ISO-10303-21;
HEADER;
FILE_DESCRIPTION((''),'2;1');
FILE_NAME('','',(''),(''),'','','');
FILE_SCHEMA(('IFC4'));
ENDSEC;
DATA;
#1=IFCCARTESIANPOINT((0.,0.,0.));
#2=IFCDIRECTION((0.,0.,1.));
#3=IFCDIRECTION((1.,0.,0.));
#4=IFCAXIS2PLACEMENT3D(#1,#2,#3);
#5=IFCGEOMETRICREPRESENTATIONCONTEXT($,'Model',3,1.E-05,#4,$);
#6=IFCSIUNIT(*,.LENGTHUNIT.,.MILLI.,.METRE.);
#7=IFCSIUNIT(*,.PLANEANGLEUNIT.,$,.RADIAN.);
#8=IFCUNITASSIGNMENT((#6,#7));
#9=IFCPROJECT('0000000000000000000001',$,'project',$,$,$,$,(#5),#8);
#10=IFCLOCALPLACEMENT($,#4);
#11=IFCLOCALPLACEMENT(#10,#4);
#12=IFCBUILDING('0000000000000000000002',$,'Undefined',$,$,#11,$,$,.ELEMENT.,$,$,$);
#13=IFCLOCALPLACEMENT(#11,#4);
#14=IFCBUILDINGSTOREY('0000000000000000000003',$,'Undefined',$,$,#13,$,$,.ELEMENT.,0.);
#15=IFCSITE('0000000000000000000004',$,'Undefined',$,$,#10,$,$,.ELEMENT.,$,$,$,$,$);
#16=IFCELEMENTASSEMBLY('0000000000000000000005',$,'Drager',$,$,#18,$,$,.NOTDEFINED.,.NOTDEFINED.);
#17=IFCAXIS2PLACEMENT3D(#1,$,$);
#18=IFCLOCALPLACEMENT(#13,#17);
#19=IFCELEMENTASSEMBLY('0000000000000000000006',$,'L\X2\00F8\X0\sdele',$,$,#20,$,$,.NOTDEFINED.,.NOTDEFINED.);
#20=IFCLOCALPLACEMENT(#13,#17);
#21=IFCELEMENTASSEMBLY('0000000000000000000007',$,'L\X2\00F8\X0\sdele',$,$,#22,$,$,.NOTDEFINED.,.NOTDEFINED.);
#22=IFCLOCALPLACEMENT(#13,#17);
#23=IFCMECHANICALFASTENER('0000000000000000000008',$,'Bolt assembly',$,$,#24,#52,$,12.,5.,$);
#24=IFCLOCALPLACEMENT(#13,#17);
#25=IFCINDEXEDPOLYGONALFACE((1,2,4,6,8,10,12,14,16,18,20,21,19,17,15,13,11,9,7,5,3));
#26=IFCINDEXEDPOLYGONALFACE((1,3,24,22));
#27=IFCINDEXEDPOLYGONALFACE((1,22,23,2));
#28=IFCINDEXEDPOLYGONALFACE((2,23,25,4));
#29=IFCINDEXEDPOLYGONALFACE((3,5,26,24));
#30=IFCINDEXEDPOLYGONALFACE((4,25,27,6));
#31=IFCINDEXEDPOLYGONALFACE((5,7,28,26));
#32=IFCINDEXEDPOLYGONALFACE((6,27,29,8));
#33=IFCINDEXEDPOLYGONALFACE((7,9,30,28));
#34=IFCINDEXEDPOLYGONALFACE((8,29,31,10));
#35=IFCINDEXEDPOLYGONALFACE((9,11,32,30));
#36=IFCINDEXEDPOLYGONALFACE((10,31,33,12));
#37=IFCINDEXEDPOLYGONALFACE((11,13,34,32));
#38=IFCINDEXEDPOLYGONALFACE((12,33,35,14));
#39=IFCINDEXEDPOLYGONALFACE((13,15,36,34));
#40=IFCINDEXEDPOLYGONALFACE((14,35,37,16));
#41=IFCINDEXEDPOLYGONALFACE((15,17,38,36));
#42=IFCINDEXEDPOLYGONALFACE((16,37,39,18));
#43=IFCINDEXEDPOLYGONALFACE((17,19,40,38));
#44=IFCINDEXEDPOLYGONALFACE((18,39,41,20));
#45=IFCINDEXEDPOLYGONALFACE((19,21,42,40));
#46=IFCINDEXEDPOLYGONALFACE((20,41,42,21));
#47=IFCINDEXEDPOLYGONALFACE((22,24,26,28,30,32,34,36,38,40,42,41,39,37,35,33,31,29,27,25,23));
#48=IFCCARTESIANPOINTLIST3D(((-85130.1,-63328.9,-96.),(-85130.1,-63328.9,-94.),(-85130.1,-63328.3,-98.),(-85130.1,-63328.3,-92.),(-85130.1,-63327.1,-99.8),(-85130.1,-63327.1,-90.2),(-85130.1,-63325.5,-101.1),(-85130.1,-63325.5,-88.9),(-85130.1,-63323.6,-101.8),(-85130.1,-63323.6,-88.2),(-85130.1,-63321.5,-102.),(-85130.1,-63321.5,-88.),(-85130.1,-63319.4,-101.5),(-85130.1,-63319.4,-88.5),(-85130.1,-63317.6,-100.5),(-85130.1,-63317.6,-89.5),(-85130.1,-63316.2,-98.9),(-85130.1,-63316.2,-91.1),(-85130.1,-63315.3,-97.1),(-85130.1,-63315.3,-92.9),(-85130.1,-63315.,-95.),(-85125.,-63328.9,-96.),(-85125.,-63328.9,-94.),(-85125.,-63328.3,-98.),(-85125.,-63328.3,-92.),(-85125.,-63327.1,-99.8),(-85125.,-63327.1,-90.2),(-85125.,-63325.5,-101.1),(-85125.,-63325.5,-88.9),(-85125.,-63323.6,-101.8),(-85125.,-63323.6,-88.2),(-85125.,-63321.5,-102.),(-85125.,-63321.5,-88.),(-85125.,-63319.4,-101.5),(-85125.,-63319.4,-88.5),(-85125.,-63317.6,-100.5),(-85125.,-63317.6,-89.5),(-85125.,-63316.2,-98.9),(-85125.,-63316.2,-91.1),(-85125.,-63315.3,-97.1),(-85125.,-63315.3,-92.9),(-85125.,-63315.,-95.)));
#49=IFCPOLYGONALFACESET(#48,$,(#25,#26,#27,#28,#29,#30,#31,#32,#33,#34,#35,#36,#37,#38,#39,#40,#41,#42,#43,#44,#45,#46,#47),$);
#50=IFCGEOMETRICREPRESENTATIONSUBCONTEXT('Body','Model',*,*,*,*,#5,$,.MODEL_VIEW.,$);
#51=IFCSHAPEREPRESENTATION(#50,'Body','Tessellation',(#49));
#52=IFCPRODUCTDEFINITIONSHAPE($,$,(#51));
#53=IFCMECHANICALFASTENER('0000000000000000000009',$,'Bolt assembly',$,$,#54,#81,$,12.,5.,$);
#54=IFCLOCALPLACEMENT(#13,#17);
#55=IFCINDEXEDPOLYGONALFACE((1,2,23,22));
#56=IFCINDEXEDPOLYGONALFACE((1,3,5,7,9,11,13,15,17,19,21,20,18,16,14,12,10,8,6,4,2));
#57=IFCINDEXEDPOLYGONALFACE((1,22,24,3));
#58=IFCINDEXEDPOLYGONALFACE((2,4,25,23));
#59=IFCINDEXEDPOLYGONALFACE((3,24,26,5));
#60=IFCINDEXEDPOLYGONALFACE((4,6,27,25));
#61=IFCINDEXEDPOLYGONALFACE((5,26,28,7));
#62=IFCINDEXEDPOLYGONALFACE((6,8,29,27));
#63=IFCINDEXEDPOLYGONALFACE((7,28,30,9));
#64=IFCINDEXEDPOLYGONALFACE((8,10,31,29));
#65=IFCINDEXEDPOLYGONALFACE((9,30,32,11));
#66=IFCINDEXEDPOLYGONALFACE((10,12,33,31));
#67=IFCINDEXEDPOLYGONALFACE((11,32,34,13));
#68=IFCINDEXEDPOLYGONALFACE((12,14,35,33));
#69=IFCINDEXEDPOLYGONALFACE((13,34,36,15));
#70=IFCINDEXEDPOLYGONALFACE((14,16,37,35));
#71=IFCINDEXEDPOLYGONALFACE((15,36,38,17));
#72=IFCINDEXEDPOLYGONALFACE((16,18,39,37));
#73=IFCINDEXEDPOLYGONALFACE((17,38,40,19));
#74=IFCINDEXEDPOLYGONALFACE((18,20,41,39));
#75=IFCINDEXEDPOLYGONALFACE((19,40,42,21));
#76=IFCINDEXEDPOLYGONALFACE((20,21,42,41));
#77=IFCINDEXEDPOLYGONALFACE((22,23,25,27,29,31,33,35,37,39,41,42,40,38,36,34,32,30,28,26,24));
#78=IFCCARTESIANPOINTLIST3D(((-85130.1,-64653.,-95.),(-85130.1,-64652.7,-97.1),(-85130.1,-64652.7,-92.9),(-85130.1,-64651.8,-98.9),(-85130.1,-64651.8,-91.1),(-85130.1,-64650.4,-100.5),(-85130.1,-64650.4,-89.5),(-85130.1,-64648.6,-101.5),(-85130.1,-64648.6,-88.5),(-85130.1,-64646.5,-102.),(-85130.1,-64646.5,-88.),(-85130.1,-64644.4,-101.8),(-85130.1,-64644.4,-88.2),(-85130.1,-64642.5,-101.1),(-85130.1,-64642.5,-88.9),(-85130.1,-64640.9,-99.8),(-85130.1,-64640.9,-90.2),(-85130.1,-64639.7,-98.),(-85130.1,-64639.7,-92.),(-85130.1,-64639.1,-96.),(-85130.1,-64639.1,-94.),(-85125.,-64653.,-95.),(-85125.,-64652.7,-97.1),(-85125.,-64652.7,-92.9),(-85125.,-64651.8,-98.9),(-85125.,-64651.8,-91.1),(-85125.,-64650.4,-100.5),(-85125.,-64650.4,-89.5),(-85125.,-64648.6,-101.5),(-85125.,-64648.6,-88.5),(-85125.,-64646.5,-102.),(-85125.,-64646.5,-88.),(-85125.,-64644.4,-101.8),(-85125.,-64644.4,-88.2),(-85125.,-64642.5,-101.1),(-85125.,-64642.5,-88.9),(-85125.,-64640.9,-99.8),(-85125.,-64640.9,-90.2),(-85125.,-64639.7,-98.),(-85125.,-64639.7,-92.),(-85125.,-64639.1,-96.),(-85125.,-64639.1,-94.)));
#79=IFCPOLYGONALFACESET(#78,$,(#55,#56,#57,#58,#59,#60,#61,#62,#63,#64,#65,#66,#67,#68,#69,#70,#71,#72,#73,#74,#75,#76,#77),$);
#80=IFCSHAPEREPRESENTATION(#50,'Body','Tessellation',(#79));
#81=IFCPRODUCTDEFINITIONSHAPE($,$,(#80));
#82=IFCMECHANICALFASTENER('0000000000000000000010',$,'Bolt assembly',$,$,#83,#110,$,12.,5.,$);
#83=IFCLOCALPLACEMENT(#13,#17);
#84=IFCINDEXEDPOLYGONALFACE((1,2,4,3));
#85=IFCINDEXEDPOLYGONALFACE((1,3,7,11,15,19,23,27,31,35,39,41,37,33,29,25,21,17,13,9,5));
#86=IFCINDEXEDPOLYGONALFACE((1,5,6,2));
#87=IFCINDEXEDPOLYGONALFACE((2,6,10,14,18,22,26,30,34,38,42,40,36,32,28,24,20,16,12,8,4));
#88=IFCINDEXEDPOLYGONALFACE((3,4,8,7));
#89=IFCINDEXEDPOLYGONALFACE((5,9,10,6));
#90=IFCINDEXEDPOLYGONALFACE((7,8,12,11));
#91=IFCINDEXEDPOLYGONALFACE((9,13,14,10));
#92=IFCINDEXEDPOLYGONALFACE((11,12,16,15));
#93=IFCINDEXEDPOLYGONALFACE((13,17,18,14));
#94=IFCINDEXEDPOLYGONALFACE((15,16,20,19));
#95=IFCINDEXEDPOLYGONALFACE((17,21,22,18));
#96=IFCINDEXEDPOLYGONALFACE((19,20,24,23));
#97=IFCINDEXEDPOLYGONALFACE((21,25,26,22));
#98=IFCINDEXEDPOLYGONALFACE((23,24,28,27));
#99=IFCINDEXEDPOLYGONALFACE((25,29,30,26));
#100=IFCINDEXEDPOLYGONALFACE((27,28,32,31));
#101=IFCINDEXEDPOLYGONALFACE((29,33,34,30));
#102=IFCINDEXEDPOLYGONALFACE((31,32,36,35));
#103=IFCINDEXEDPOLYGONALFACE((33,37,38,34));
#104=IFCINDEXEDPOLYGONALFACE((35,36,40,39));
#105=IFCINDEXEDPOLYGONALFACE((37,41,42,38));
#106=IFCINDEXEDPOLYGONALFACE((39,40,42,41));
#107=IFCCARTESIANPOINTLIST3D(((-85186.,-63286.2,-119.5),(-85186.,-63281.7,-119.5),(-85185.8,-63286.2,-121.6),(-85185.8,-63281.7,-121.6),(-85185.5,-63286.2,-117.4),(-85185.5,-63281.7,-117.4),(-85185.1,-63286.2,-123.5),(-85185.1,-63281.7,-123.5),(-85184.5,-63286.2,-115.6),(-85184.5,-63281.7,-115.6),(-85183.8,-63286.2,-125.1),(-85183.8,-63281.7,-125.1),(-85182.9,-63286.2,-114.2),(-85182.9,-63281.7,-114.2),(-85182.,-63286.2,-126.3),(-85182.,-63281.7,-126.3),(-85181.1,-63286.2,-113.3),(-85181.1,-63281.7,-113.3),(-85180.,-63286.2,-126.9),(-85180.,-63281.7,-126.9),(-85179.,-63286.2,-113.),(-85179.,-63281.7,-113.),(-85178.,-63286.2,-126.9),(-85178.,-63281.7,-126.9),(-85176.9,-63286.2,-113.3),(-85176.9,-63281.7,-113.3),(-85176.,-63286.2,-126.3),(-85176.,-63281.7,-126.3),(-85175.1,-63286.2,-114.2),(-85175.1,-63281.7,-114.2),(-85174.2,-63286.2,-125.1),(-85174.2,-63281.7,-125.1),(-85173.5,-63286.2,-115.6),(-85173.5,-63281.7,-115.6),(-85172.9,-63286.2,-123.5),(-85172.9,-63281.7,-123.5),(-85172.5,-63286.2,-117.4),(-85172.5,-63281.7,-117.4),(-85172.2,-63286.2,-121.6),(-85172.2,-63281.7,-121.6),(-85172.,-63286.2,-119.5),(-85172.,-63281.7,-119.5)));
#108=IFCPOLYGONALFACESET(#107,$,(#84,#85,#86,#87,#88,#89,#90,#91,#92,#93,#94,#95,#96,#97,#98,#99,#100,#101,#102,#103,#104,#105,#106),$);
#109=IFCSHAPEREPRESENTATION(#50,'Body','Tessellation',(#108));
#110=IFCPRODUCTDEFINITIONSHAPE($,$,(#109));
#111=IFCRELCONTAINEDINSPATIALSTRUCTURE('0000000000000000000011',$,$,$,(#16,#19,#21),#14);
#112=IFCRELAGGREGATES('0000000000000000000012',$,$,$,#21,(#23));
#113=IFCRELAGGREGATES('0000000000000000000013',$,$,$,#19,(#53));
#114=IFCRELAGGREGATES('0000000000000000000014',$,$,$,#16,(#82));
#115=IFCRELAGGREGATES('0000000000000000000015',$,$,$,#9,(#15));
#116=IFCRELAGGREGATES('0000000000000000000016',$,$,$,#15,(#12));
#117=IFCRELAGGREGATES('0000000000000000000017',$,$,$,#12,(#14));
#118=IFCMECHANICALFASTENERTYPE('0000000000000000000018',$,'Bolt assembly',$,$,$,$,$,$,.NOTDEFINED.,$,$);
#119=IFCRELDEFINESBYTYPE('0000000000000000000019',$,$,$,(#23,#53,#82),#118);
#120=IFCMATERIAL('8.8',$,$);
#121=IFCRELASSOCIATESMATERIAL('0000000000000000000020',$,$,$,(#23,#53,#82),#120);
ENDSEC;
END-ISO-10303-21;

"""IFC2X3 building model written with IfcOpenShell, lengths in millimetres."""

from ifc_helpers import new_model, si_unit, frame, origin_with_axes, origin_2d_with_axis, place, context, subcontext, project, spatial, circle, extrude, source, transform, mapped, material, type_object, element, aggregate, save


model = new_model("IFC2X3")

# Units and contexts
model_context = context("Model", 3, precision=1e-05, world=origin_with_axes())
body_context = subcontext(model_context, "Body", "Model", "MODEL_VIEW")
ifc_project = project(units=[si_unit("LENGTHUNIT", "METRE", prefix="MILLI"), si_unit("PLANEANGLEUNIT", "RADIAN")], contexts=[model_context])

# Site, building, storey
site_placement = place(None, origin_with_axes())
site = spatial("IfcSite", under=ifc_project, at=site_placement, Name="Undefined", CompositionType="ELEMENT")
building_placement = place(site_placement, origin_with_axes())
building = spatial("IfcBuilding", under=site, at=building_placement, Name="Undefined", CompositionType="ELEMENT")
storey_placement = place(building_placement, origin_with_axes())
storey = spatial("IfcBuildingStorey", under=building, at=storey_placement, Name="Undefined", CompositionType="ELEMENT", Elevation=0.0)

# Element assembly
assembly_1_placement = place(storey_placement, origin_with_axes())
assembly_1 = element("IfcElementAssembly", 1, at=assembly_1_placement, inside=storey, Name="Drager", AssemblyPlace="NOTDEFINED", PredefinedType="NOTDEFINED")

# Element assemblies
assembly_2_placement = place(storey_placement, origin_with_axes())
assembly_2 = element("IfcElementAssembly", 2, at=assembly_2_placement, inside=storey, Name="Løsdele", AssemblyPlace="NOTDEFINED", PredefinedType="NOTDEFINED")
assembly_3_placement = place(storey_placement, origin_with_axes())
assembly_3 = element("IfcElementAssembly", 3, at=assembly_3_placement, inside=storey, Name="Løsdele", AssemblyPlace="NOTDEFINED", PredefinedType="NOTDEFINED")

# Shared definitions
ifc_material_1 = material(Name="8.8")
mechanical_fastener_type = type_object("IfcMechanicalFastenerType", Name="Bolt assembly")

# Mechanical fasteners
shared_shape_1 = source(origin_with_axes(), body_context, "Body", "SweptSolid", [
    extrude(circle(Radius=7.0, at=origin_2d_with_axis()), frame((0.0, 5.0, 0.0), z_axis=(0.0, 1.0, 0.0), x_axis=(1.0, 0.0, 0.0)), (0.0, 0.0, 1.0), 5.1),
])
mechanical_fastener_1_placement = place(assembly_3_placement, frame((-85120.0, -63322.0, -95.0), z_axis=(0.0, 0.0, 1.0), x_axis=(0.0, 1.0, 0.0)))
mechanical_fastener_1 = element("IfcMechanicalFastener", 4, at=mechanical_fastener_1_placement, type_object=mechanical_fastener_type, material=ifc_material_1, Name="Bolt assembly", NominalDiameter=12.0, NominalLength=5.0, context=body_context, shape_type="MappedRepresentation", body=[
    mapped(shared_shape_1, transform((0.0, 0.0, 0.0))),
])
aggregate(assembly_3, [mechanical_fastener_1])
mechanical_fastener_2_placement = place(assembly_2_placement, frame((-85120.0, -64646.0, -95.0), z_axis=(0.0, 0.0, -1.0), x_axis=(0.0, -1.0, 0.0)))
mechanical_fastener_2 = element("IfcMechanicalFastener", 5, at=mechanical_fastener_2_placement, type_object=mechanical_fastener_type, material=ifc_material_1, Name="Bolt assembly", NominalDiameter=12.0, NominalLength=5.0, context=body_context, shape_type="MappedRepresentation", body=[
    mapped(shared_shape_1, transform((0.0, 0.0, 0.0))),
])
aggregate(assembly_2, [mechanical_fastener_2])
shared_shape_2 = source(origin_with_axes(), body_context, "Body", "SweptSolid", [
    extrude(circle(Radius=7.0, at=origin_2d_with_axis()), frame((0.0, 5.3, 0.0), z_axis=(0.0, 1.0, 0.0), x_axis=(1.0, 0.0, 0.0)), (0.0, 0.0, 1.0), 4.5),
])
mechanical_fastener_3_placement = place(assembly_1_placement, frame((-85179.0, -63291.5, -120.0), z_axis=(-1.0, 0.0, 0.0), x_axis=(0.0, 0.0, 1.0)))
mechanical_fastener_3 = element("IfcMechanicalFastener", 6, at=mechanical_fastener_3_placement, type_object=mechanical_fastener_type, material=ifc_material_1, Name="Bolt assembly", NominalDiameter=12.0, NominalLength=5.0, context=body_context, shape_type="MappedRepresentation", body=[
    mapped(shared_shape_2, transform((0.0, 0.0, 0.0))),
])
aggregate(assembly_1, [mechanical_fastener_3])

save(model, "model.ifc")
